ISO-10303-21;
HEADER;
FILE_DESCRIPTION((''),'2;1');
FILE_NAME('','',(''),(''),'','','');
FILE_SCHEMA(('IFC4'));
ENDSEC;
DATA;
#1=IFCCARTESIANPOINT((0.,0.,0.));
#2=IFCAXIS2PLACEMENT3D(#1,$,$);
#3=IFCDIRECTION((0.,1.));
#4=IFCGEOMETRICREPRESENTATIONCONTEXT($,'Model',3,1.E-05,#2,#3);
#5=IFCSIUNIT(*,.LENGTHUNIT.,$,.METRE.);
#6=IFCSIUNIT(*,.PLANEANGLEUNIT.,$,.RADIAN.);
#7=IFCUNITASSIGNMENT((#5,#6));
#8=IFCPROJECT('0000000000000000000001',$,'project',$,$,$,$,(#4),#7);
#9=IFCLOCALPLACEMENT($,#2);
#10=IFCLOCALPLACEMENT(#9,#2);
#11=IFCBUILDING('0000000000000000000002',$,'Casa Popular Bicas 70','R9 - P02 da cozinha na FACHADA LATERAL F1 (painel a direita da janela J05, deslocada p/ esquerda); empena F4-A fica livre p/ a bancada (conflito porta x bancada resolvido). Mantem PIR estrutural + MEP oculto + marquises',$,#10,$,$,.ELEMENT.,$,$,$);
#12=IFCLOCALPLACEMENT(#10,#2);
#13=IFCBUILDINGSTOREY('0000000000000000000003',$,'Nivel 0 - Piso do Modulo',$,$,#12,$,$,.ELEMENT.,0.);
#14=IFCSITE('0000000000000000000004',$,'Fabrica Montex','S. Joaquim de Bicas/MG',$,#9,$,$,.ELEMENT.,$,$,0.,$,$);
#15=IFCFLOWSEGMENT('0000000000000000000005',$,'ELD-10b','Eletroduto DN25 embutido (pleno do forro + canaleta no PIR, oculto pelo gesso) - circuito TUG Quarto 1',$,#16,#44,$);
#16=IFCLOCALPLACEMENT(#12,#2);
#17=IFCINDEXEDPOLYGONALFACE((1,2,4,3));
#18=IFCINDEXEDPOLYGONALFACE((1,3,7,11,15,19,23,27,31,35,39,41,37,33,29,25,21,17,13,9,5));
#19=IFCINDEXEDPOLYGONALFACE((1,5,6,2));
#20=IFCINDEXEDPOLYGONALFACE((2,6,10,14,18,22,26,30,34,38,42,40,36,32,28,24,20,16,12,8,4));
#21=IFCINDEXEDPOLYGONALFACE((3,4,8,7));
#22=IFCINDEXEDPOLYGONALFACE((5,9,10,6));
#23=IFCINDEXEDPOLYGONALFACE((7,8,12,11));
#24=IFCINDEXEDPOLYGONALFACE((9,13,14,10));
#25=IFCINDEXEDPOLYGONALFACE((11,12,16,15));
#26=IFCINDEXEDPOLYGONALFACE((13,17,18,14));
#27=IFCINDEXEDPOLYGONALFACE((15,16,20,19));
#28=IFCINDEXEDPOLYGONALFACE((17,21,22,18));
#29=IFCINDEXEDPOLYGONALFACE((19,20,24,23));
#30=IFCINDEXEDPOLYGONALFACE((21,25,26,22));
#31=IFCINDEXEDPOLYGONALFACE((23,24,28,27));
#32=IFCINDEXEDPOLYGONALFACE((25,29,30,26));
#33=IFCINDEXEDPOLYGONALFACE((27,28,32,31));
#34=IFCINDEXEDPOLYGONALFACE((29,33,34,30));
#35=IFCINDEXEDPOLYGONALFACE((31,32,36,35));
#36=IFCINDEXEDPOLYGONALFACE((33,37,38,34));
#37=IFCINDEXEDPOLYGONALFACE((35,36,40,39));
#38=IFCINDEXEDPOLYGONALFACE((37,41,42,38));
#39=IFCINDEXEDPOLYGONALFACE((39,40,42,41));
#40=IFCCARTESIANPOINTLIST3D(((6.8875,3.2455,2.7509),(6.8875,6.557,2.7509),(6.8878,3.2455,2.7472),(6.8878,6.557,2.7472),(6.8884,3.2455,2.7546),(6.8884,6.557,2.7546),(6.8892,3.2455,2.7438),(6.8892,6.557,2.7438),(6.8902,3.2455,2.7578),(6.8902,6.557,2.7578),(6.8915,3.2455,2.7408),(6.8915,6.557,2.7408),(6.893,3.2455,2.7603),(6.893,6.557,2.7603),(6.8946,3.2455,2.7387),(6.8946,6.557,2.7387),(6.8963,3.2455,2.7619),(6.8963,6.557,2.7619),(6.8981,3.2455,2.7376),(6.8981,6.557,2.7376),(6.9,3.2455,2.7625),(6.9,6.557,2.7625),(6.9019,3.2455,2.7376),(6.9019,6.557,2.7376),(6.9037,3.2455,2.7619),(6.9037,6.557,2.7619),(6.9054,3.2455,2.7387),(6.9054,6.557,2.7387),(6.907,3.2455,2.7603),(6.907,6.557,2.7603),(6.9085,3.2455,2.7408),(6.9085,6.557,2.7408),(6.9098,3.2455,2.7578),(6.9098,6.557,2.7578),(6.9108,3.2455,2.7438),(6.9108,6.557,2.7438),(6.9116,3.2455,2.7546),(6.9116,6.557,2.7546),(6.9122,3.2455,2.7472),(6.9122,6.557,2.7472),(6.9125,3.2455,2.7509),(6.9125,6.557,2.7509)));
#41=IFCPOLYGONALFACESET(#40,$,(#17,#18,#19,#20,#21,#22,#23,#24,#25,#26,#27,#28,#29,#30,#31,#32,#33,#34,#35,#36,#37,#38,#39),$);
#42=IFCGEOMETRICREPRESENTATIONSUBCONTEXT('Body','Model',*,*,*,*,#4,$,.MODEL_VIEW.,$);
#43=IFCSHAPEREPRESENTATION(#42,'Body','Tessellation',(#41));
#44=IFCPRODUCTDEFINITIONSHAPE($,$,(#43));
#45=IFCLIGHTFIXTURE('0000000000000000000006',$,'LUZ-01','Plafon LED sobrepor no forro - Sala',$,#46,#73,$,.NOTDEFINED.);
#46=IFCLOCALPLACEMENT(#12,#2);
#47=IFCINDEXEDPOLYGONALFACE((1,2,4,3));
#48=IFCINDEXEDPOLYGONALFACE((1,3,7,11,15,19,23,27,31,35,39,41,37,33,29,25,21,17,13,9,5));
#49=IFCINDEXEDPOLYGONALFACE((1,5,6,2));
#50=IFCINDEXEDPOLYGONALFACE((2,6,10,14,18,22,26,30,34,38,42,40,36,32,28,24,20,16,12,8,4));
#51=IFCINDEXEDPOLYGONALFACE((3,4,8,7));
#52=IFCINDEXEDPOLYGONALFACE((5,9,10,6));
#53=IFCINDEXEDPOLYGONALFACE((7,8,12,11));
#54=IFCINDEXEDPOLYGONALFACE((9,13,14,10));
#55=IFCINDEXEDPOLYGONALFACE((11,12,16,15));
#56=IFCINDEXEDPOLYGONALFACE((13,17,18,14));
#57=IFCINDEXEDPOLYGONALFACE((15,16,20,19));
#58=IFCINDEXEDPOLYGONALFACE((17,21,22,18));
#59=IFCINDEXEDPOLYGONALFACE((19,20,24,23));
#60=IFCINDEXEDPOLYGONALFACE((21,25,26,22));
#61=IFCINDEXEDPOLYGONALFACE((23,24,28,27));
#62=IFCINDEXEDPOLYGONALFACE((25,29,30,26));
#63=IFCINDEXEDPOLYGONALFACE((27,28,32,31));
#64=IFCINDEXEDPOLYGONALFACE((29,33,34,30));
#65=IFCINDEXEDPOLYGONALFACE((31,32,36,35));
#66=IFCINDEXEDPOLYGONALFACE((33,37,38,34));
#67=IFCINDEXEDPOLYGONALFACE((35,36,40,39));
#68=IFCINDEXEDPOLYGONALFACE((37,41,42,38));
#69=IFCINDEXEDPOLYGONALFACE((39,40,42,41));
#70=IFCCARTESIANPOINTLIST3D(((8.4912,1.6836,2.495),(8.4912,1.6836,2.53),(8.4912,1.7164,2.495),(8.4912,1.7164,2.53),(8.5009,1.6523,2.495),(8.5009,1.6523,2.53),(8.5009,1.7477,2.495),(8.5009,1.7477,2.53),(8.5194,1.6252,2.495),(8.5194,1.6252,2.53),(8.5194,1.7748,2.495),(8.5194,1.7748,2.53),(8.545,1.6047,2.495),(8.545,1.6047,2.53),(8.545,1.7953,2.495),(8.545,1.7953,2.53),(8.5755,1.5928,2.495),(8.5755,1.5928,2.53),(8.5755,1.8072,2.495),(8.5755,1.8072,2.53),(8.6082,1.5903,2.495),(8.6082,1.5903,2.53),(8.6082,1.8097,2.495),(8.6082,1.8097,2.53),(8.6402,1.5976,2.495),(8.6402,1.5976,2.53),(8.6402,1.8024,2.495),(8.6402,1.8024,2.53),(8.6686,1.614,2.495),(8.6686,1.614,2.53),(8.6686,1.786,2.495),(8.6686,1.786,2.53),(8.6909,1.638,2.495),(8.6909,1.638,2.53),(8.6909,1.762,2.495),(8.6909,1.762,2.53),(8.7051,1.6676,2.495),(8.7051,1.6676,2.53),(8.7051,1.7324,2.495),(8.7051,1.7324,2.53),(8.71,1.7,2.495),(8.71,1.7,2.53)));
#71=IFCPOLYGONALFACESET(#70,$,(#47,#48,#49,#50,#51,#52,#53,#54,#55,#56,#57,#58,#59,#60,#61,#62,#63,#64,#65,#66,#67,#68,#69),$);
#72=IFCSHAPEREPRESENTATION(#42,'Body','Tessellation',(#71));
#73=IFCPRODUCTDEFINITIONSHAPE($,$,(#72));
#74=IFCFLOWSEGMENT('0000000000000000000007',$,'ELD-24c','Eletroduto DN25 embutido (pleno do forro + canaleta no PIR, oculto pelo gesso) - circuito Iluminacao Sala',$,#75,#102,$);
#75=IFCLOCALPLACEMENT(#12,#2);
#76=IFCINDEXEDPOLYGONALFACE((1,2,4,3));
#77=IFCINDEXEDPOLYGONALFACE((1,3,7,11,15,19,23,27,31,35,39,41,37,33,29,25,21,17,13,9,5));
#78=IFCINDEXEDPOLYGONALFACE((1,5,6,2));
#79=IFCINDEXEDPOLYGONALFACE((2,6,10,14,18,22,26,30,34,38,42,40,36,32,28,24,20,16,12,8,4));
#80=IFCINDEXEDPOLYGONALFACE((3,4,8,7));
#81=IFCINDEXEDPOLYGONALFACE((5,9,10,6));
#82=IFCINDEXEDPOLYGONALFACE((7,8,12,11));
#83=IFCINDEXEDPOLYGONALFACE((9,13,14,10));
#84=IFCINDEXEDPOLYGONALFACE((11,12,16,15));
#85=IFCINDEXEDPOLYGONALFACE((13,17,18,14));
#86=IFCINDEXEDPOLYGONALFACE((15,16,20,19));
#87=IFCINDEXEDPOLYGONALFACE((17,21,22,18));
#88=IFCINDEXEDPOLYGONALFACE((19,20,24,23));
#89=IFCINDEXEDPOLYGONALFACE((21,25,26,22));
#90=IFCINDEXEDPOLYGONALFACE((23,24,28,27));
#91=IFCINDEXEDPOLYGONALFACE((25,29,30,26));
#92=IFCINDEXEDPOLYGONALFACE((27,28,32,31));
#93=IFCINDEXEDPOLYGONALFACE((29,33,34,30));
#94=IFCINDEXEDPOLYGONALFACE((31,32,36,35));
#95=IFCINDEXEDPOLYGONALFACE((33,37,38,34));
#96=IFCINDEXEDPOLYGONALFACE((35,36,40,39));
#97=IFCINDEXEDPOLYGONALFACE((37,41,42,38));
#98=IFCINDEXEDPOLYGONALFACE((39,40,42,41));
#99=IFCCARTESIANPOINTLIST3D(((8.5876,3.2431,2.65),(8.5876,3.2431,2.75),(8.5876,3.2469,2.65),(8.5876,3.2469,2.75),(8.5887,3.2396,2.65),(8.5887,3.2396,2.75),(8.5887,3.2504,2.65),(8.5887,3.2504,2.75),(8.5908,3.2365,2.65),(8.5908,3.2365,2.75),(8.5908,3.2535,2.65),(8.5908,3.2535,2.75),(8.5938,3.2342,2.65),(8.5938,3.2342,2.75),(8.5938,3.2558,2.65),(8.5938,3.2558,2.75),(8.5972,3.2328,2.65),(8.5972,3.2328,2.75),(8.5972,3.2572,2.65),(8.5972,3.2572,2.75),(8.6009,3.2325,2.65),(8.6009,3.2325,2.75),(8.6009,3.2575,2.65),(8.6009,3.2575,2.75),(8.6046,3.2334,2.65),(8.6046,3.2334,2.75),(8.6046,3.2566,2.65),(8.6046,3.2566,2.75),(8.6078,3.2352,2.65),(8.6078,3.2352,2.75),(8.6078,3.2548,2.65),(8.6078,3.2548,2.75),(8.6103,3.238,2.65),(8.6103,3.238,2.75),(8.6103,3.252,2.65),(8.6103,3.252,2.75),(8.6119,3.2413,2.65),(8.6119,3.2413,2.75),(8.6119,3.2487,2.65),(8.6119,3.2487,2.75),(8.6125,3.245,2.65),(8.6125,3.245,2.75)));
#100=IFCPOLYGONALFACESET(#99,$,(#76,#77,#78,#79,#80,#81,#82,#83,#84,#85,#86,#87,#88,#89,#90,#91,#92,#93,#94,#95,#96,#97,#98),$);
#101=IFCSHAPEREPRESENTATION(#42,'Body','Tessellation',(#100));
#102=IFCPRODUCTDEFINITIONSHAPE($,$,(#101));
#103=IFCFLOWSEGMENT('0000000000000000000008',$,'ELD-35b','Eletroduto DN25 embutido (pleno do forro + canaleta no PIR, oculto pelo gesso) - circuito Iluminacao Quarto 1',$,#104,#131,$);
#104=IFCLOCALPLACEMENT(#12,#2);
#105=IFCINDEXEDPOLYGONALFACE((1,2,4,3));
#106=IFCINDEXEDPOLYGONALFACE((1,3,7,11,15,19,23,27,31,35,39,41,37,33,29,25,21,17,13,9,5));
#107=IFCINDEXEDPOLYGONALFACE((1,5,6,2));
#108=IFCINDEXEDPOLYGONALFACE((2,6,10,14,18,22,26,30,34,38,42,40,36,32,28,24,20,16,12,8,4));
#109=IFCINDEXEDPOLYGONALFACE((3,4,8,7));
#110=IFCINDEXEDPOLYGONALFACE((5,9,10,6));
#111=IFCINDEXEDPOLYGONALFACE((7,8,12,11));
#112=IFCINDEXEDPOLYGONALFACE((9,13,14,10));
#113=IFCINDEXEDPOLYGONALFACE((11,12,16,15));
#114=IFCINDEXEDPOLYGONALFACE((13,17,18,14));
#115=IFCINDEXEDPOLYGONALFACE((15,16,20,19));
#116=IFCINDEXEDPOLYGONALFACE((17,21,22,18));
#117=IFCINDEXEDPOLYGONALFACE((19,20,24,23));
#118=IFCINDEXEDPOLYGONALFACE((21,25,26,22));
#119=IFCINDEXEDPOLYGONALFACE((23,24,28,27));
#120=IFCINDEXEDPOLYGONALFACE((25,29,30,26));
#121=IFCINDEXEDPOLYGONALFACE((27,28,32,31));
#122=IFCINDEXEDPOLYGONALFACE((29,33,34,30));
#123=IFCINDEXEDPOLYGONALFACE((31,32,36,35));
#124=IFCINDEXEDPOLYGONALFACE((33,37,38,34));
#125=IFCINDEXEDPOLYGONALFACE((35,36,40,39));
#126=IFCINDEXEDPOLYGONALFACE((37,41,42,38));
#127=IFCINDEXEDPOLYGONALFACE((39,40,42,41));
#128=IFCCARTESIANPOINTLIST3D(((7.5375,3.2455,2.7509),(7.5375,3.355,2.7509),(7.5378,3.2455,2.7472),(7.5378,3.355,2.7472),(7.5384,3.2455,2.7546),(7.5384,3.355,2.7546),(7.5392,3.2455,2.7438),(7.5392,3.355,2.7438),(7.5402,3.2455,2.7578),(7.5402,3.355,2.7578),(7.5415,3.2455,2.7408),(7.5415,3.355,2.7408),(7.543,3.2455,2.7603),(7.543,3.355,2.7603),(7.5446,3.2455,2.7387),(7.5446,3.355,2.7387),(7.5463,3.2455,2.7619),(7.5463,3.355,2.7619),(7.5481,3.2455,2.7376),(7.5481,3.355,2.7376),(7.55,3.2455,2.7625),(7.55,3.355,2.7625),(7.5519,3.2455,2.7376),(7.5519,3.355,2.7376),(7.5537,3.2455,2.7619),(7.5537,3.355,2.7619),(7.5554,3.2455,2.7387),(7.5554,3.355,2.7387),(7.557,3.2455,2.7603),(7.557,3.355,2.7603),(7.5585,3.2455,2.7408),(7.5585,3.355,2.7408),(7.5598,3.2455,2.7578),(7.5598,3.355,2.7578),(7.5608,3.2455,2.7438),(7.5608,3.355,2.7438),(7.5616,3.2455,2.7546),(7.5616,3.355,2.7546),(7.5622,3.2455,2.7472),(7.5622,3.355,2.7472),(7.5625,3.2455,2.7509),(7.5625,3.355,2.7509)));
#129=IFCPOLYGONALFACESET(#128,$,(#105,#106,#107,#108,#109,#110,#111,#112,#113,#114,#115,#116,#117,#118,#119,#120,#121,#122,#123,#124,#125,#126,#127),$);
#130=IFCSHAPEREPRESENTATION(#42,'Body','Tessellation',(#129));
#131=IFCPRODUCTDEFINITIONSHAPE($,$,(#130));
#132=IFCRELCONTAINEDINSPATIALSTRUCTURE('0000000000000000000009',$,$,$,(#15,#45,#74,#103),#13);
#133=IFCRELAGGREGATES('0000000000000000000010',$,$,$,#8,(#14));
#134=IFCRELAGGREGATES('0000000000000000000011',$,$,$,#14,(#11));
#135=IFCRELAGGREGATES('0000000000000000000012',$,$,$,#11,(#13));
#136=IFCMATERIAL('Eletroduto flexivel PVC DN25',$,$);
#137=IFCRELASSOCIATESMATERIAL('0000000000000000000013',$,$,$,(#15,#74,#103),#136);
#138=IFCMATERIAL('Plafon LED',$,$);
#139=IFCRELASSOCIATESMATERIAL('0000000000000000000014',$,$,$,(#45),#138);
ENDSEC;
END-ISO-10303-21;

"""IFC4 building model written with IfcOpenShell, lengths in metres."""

from ifc_helpers import new_model, si_unit, direction, frame, origin, origin_2d, place, context, subcontext, project, spatial, circle, extrude, material, element, save


model = new_model("IFC4")

# Units and contexts
model_context = context("Model", 3, precision=1e-05, world=origin(), true_north=direction((0.0, 1.0)))
body_context = subcontext(model_context, "Body", "Model", "MODEL_VIEW")
ifc_project = project(units=[si_unit("LENGTHUNIT", "METRE"), si_unit("PLANEANGLEUNIT", "RADIAN")], contexts=[model_context])

# Site, building, storey
site_placement = place(None, origin())
site = spatial("IfcSite", under=ifc_project, at=site_placement, Name="Fabrica Montex", Description="S. Joaquim de Bicas/MG", CompositionType="ELEMENT", RefElevation=0.0)
building_placement = place(site_placement, origin())
building = spatial("IfcBuilding", under=site, at=building_placement, Name="Casa Popular Bicas 70", Description="R9 - P02 da cozinha na FACHADA LATERAL F1 (painel a direita da janela J05, deslocada p/ esquerda); empena F4-A fica livre p/ a bancada (conflito porta x bancada resolvido). Mantem PIR estrutural + MEP oculto + marquises", CompositionType="ELEMENT")
storey_placement = place(building_placement, origin())
storey = spatial("IfcBuildingStorey", under=building, at=storey_placement, Name="Nivel 0 - Piso do Modulo", CompositionType="ELEMENT", Elevation=0.0)

# Flow segment
ifc_material_1 = material(Name="Eletroduto flexivel PVC DN25")
flow_segment_1_placement = place(storey_placement, frame((6.9, 3.2455, 2.75), z_axis=(0.0, 1.0, 0.0), x_axis=(0.0, 0.0, 1.0)))
element("IfcFlowSegment", 1, at=flow_segment_1_placement, inside=storey, material=ifc_material_1, Name="ELD-10b", Description="Eletroduto DN25 embutido (pleno do forro + canaleta no PIR, oculto pelo gesso) - circuito TUG Quarto 1", context=body_context, shape_type="SweptSolid", body=[
    extrude(circle(Radius=0.0125, at=origin_2d()), origin(), (0.0, 0.0, 1.0), 3.3115),
])

# Light fixture
ifc_material_2 = material(Name="Plafon LED")
light_fixture_placement = place(storey_placement, frame((8.6, 1.7, 2.495)))
element("IfcLightFixture", 2, at=light_fixture_placement, inside=storey, material=ifc_material_2, Name="LUZ-01", Description="Plafon LED sobrepor no forro - Sala", PredefinedType="NOTDEFINED", context=body_context, shape_type="SweptSolid", body=[
    extrude(circle(Radius=0.11, at=origin_2d()), origin(), (0.0, 0.0, 1.0), 0.035),
])

# Flow segments
flow_segment_2_placement = place(storey_placement, frame((8.6, 3.245, 2.75), z_axis=(0.0, 0.0, -1.0), x_axis=(1.0, 0.0, 0.0)))
element("IfcFlowSegment", 3, at=flow_segment_2_placement, inside=storey, material=ifc_material_1, Name="ELD-24c", Description="Eletroduto DN25 embutido (pleno do forro + canaleta no PIR, oculto pelo gesso) - circuito Iluminacao Sala", context=body_context, shape_type="SweptSolid", body=[
    extrude(circle(Radius=0.0125, at=origin_2d()), origin(), (0.0, 0.0, 1.0), 0.1),
])
flow_segment_3_placement = place(storey_placement, frame((7.55, 3.2455, 2.75), z_axis=(0.0, 1.0, 0.0), x_axis=(0.0, 0.0, 1.0)))
element("IfcFlowSegment", 4, at=flow_segment_3_placement, inside=storey, material=ifc_material_1, Name="ELD-35b", Description="Eletroduto DN25 embutido (pleno do forro + canaleta no PIR, oculto pelo gesso) - circuito Iluminacao Quarto 1", context=body_context, shape_type="SweptSolid", body=[
    extrude(circle(Radius=0.0125, at=origin_2d()), origin(), (0.0, 0.0, 1.0), 0.1095),
])

save(model, "model.ifc")
